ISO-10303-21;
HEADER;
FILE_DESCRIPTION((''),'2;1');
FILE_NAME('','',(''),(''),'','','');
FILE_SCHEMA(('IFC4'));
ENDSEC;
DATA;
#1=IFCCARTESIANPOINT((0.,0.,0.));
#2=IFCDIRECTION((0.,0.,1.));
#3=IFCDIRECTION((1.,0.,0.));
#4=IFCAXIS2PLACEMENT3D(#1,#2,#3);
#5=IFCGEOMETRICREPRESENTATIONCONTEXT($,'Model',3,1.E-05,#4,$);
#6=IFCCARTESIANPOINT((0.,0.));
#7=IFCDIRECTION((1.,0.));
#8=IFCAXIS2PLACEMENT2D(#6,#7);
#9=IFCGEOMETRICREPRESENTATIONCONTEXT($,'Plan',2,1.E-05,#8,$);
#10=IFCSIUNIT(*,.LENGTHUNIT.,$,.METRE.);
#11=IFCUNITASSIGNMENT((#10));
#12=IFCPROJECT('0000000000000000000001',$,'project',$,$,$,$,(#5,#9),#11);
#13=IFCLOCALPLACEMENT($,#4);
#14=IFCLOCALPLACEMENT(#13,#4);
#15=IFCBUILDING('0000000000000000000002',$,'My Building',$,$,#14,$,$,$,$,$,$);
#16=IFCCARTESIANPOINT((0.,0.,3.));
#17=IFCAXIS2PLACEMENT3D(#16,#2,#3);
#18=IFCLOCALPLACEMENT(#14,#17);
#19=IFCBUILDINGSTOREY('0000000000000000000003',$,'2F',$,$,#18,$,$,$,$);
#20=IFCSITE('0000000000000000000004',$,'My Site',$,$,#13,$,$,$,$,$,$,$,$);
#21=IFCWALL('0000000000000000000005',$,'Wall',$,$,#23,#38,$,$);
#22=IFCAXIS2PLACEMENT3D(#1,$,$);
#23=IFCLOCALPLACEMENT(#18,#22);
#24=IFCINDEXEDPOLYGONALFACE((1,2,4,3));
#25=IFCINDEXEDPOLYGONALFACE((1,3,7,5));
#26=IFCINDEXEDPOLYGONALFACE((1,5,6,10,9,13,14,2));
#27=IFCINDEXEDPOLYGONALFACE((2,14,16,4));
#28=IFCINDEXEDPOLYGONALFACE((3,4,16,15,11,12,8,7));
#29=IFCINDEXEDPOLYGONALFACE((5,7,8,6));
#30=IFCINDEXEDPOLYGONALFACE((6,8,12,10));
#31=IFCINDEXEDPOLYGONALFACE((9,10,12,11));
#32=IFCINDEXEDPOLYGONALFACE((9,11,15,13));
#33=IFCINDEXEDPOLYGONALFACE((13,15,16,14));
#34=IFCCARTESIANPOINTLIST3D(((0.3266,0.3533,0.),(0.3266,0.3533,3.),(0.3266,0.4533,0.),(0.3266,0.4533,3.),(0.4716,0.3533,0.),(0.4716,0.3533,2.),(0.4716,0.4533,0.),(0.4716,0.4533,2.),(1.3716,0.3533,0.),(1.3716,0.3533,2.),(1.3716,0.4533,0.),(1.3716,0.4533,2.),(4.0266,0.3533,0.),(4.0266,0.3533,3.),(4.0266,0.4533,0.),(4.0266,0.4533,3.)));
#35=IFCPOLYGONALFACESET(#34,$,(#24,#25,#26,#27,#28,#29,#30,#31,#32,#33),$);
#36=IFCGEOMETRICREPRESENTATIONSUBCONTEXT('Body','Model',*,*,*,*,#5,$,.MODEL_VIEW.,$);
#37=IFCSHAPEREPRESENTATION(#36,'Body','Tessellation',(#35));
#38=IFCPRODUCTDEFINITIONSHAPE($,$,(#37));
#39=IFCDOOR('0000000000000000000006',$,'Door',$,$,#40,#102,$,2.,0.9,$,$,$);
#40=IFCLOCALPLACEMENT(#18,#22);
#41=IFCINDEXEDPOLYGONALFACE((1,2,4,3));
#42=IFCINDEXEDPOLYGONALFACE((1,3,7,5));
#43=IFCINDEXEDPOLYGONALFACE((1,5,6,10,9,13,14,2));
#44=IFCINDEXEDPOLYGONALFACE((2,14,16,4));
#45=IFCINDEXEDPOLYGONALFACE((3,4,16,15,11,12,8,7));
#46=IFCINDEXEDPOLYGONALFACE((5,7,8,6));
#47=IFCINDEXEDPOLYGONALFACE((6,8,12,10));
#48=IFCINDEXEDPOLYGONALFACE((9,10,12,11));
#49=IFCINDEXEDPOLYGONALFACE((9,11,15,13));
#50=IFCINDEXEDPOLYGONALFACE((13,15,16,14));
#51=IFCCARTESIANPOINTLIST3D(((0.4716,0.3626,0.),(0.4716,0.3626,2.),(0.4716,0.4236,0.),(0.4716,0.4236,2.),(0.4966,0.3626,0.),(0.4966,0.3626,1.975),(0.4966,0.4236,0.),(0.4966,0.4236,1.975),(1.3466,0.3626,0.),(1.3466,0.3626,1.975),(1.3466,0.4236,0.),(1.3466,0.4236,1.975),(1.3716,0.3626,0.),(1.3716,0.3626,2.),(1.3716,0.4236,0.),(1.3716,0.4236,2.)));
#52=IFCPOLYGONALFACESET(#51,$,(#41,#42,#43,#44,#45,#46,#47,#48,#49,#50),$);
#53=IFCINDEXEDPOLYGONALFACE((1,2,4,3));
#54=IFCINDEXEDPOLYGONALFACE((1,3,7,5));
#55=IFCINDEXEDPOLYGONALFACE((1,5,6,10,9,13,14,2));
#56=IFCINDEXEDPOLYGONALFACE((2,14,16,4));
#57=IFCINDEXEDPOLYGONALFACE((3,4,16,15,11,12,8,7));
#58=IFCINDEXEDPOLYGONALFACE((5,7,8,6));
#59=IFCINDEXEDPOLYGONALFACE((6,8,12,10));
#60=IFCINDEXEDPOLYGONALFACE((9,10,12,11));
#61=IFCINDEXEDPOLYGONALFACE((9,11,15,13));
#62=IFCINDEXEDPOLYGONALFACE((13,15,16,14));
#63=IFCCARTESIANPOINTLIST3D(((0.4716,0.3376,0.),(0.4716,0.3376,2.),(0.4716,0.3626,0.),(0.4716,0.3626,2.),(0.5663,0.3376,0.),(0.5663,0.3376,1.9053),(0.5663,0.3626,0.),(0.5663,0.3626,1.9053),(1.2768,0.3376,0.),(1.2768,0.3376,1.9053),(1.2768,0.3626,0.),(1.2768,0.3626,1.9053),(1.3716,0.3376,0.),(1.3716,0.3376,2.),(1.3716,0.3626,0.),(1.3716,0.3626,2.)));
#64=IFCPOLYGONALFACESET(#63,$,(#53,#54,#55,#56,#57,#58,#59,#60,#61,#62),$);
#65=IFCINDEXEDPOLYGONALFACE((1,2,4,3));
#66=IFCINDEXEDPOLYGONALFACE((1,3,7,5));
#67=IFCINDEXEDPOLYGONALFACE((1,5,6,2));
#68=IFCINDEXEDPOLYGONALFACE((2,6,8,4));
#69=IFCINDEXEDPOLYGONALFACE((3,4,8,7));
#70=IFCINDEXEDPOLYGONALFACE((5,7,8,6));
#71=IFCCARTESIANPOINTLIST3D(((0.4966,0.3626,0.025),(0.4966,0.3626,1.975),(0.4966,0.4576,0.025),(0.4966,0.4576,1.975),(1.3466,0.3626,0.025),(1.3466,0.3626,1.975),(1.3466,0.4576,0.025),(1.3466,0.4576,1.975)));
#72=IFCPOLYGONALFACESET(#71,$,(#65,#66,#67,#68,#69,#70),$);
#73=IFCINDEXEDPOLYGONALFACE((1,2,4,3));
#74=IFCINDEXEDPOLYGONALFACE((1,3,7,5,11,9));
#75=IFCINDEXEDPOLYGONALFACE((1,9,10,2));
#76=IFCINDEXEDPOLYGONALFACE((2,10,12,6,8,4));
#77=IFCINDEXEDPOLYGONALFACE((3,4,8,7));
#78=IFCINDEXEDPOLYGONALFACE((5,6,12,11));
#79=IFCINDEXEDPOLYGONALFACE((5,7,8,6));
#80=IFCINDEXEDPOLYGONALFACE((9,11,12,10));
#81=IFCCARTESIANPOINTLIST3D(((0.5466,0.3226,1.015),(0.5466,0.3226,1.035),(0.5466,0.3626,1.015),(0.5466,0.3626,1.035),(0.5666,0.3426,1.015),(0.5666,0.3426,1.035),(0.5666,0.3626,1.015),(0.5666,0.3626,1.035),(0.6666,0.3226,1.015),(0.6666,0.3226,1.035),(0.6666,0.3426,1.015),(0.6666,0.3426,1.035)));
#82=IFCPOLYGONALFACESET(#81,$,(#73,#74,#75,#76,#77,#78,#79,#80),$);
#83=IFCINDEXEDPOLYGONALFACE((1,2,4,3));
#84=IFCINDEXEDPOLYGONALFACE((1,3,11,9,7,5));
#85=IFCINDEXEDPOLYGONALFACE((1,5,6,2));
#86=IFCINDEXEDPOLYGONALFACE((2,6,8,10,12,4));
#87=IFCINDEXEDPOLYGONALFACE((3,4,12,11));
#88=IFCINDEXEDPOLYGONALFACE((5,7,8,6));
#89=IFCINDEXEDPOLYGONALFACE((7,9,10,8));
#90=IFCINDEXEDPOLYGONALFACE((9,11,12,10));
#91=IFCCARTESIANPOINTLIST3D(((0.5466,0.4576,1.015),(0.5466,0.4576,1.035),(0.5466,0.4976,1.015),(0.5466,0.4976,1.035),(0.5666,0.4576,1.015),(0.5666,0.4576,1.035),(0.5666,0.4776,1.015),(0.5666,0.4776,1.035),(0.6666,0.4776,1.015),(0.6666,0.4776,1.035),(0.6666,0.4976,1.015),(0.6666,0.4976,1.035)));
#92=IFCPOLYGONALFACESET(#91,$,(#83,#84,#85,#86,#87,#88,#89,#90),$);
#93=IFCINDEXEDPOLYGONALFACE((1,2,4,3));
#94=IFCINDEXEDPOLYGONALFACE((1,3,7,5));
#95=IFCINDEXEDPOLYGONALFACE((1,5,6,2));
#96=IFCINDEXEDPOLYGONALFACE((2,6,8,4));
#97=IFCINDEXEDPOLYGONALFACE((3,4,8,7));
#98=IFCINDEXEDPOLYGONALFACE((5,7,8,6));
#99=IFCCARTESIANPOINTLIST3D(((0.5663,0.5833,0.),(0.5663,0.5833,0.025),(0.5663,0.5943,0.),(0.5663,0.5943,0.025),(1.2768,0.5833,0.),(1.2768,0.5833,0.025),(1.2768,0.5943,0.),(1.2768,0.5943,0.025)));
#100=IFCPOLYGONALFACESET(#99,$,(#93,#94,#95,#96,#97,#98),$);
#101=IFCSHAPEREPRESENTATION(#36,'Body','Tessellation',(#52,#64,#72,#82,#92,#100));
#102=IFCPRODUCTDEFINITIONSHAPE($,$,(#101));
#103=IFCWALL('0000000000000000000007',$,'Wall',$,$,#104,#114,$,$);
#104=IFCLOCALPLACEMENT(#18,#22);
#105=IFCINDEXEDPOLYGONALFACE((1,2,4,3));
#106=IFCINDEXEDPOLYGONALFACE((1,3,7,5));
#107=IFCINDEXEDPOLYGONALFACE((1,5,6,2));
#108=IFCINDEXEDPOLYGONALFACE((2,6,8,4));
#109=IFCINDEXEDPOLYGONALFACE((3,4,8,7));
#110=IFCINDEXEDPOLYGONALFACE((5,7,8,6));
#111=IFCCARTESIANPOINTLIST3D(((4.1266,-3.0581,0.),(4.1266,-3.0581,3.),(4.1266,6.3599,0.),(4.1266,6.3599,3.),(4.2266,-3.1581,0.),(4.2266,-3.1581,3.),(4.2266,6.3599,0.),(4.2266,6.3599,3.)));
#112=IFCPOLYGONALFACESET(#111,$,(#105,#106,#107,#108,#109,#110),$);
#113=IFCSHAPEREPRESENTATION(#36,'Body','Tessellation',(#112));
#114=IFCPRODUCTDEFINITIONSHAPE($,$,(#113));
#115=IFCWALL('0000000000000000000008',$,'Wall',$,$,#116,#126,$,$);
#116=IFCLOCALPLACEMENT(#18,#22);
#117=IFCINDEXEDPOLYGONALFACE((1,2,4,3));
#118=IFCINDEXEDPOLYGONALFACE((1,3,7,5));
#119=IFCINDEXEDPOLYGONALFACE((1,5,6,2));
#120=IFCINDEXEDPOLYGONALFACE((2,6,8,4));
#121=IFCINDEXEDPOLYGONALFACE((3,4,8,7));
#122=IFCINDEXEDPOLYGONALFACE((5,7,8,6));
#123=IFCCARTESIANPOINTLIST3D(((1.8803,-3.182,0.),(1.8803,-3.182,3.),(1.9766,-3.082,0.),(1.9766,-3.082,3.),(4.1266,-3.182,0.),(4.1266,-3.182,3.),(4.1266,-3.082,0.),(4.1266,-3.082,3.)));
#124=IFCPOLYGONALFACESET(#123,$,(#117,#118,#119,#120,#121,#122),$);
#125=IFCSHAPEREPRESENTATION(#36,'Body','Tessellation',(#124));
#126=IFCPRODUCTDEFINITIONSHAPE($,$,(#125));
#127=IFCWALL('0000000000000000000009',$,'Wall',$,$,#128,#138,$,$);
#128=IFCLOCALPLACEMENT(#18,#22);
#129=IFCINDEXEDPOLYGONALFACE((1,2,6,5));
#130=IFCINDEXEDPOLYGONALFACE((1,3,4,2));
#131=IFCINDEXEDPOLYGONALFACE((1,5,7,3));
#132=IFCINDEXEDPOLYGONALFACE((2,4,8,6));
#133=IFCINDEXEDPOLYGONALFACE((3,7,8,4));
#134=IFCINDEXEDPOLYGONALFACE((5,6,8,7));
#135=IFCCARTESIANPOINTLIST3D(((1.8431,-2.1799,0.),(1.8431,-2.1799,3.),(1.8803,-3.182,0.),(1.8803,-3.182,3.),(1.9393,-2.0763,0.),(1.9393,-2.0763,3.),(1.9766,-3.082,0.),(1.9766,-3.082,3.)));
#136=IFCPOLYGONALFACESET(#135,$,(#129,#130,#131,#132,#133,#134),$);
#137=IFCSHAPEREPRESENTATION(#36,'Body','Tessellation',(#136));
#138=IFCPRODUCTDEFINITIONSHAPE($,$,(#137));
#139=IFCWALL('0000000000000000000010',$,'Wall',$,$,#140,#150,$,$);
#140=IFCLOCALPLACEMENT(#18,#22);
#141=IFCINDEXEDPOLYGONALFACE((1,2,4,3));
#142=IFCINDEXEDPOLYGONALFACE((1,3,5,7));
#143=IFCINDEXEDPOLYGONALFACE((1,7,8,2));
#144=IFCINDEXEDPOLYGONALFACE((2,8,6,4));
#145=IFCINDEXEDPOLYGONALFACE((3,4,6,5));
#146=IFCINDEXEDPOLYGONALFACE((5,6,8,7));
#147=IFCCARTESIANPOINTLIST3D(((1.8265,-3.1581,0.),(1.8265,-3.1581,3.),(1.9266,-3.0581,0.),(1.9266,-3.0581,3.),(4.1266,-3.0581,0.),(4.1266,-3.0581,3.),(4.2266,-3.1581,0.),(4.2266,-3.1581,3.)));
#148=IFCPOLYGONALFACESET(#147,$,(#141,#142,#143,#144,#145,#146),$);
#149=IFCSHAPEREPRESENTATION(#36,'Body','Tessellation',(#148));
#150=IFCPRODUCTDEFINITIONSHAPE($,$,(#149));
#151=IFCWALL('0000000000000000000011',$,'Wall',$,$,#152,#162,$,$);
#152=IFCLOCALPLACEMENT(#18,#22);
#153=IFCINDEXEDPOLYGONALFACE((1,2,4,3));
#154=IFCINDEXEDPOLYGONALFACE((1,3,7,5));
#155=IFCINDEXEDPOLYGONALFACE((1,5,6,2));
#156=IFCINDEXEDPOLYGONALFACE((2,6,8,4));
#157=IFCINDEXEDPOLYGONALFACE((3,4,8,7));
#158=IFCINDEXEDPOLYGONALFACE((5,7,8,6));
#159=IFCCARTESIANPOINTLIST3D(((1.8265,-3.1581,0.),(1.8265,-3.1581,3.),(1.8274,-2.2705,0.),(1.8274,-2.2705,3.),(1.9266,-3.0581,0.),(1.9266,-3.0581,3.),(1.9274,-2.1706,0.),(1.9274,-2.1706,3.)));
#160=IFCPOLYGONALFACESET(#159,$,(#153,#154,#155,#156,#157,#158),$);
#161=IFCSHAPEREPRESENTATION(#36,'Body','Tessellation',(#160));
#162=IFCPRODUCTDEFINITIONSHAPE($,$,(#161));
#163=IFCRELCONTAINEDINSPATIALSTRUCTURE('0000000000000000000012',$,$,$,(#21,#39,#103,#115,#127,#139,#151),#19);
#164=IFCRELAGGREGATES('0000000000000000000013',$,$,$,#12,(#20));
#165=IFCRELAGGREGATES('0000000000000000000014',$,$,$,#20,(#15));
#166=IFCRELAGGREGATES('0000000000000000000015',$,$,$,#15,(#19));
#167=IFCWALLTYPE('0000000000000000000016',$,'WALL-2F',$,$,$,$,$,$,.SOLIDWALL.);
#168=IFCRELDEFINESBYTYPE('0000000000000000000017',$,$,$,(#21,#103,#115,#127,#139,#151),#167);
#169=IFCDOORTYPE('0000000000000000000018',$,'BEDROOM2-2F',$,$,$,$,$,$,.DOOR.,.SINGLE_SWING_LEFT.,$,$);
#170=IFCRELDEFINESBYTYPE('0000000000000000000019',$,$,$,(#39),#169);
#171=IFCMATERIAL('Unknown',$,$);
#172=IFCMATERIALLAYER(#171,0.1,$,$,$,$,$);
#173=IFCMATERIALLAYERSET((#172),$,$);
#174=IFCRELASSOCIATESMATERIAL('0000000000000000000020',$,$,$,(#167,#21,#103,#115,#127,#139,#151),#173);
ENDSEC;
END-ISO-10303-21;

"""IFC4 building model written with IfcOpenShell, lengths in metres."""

from ifc_helpers import new_model, entity, si_unit, frame, origin_with_axes, origin_2d_with_axis, place, context, subcontext, project, spatial, line, indexed_curve, outline, extrude, shape, source, transform, mapped, material, layer, layer_set, layer_usage, type_object, type_shapes, element, fill, save


model = new_model("IFC4")

# Units and contexts
model_context = context("Model", 3, precision=1e-05, world=origin_with_axes())
plan_context = context("Plan", 2, precision=1e-05, world=origin_2d_with_axis())
body_context_1 = subcontext(model_context, "Body", "Model", "MODEL_VIEW")
body_context_2 = subcontext(plan_context, "Body", "Plan", "PLAN_VIEW")
ifc_project = project(units=[si_unit("LENGTHUNIT", "METRE")], contexts=[model_context, plan_context])

# Site, building, storey
site_placement = place(None, origin_with_axes())
site = spatial("IfcSite", under=ifc_project, at=site_placement, Name="My Site")
building_placement = place(site_placement, origin_with_axes())
building = spatial("IfcBuilding", under=site, at=building_placement, Name="My Building")
storey_placement = place(building_placement, frame((0.0, 0.0, 3.0), z_axis=(0.0, 0.0, 1.0), x_axis=(1.0, 0.0, 0.0)))
storey = spatial("IfcBuildingStorey", under=building, at=storey_placement, Name="2F")

# Shared definitions
ifc_material = material(Name="Unknown")

# Shared definitions
ifc_layer_1 = layer(ifc_material, 0.1)
ifc_layer_set_1 = layer_set([ifc_layer_1])
wall_type = type_object("IfcWallType", Name="WALL-2F", PredefinedType="SOLIDWALL", material=ifc_layer_set_1)

# Wall, opening, door
ifc_layer_usage_1 = layer_usage(ifc_layer_set_1, "AXIS2", "POSITIVE", 0.0)
wall_1_placement = place(storey_placement, frame((4.0266, 0.4533, 0.0), z_axis=(0.0, 0.0, 1.0), x_axis=(-1.0, 0.0, 0.0)))
wall_1 = element("IfcWall", 1, at=wall_1_placement, inside=storey, type_object=wall_type, material=ifc_layer_usage_1, Name="Wall", context=body_context_1, shape_type="SweptSolid", body=[
    extrude(outline(indexed_curve([(0.0, 0.0), (0.0, 0.1), (3.7, 0.1), (3.7, 0.0)], segments=[line(1, 2, 3, 4, 1)])), origin_with_axes(), (0.0, 0.0, 1.0), 3.0),
])
shared_shape_1 = source(origin_with_axes(), body_context_1, "Body", "SweptSolid", [
    extrude(outline(indexed_curve([(0.0, 0.0), (0.9, 0.0), (0.9, 2.0), (0.0, 2.0)], segments=[line(1, 2, 3, 4, 1)])), frame((0.0, -0.6, 0.0), z_axis=(0.0, -1.0, 0.0), x_axis=(1.0, 0.0, 0.0)), (0.0, 0.0, -1.0), 1.2),
])
opening_1_placement = place(wall_1_placement, frame((3.5551, 0.1, 0.0), z_axis=(0.0, 0.0, 1.0), x_axis=(-1.0, 0.0, 0.0)))
opening_1 = element("IfcOpeningElement", 2, at=opening_1_placement, cuts=wall_1, PredefinedType="OPENING", context=body_context_1, shape_type="MappedRepresentation", body=[
    mapped(shared_shape_1, transform((0.0, 0.0, 0.0), x_axis=(1.0, 0.0, 0.0), y_axis=(0.0, 1.0, 0.0), z_axis=(0.0, 0.0, 1.0), scale=1.0)),
])
door_type_1 = type_object("IfcDoorType", Name="BEDROOM2-2F", OperationType="SINGLE_SWING_LEFT", PredefinedType="DOOR")
shared_shape_2 = source(origin_with_axes(), body_context_1, "Body", "SweptSolid", [
    extrude(outline(indexed_curve([(0.0, 0.0), (0.0, 2.0), (0.9, 2.0), (0.9, 0.0), (0.875, 0.0), (0.875, 1.975), (0.025, 1.975), (0.025, 0.0)], segments=[line(1, 2, 3, 4, 5, 6, 7, 8, 1)])), frame((0.0, 0.0093, 0.0), z_axis=(0.0, -1.0, 0.0), x_axis=(1.0, 0.0, 0.0)), (0.0, 0.0, -1.0), 0.061),
    extrude(outline(indexed_curve([(0.0, 0.0), (0.0, 2.0), (0.9, 2.0), (0.9, 0.0), (0.8053, 0.0), (0.8053, 1.9053), (0.0947, 1.9053), (0.0947, 0.0)], segments=[line(1, 2, 3, 4, 5, 6, 7, 8, 1)])), frame((0.0, -0.0157, 0.0), z_axis=(0.0, -1.0, 0.0), x_axis=(1.0, 0.0, 0.0)), (0.0, 0.0, -1.0), 0.025),
    extrude(outline(indexed_curve([(0.0, 0.0), (0.85, 0.0), (0.85, 0.095), (0.0, 0.095)], segments=[line(1, 2, 3, 4, 1)])), frame((0.025, 0.0093, 0.025), z_axis=(0.0, 0.0, 1.0), x_axis=(1.0, 0.0, 0.0)), (0.0, 0.0, 1.0), 1.95),
    extrude(outline(indexed_curve([(0.0, 0.0), (0.0, -0.04), (0.12, -0.04), (0.12, -0.02), (0.02, -0.02), (0.02, 0.0)], segments=[line(1, 2, 3, 4, 5, 6, 1)])), frame((0.075, 0.0093, 1.015), z_axis=(0.0, 0.0, 1.0), x_axis=(1.0, 0.0, 0.0)), (0.0, 0.0, 1.0), 0.02),
    extrude(outline(indexed_curve([(0.0, 0.0), (0.0, 0.04), (0.12, 0.04), (0.12, 0.02), (0.02, 0.02), (0.02, 0.0)], segments=[line(1, 2, 3, 4, 5, 6, 1)])), frame((0.075, 0.1043, 1.015), z_axis=(0.0, 0.0, 1.0), x_axis=(1.0, 0.0, 0.0)), (0.0, 0.0, 1.0), 0.02),
    extrude(outline(indexed_curve([(0.0, 0.0), (0.7105, 0.0), (0.7105, 0.011), (0.0, 0.011)], segments=[line(1, 2, 3, 4, 1)])), frame((0.0947, 0.23, 0.0), z_axis=(0.0, 0.0, 1.0), x_axis=(1.0, 0.0, 0.0)), (0.0, 0.0, 1.0), 0.025),
])
shared_shape_3 = source(origin_with_axes(), body_context_2, "Body", "Curve2D", [
    entity("IfcIndexedPolyCurve", entity("IfcCartesianPointList2D", [[0.0, -0.0157], [0.0, 0.0703], [0.025, 0.0703], [0.025, 0.0093], [0.0947, 0.0093], [0.0947, -0.0157]]), [entity("IfcLineIndex", [1, 2, 3, 4, 5, 6, 1])]),
    entity("IfcIndexedPolyCurve", entity("IfcCartesianPointList2D", [[0.9, -0.0157], [0.9, 0.0703], [0.875, 0.0703], [0.875, 0.0093], [0.8053, 0.0093], [0.8053, -0.0157]]), [entity("IfcLineIndex", [1, 2, 3, 4, 5, 6, 1])]),
    entity("IfcTrimmedCurve", entity("IfcEllipse", entity("IfcAxis2Placement2D", entity("IfcCartesianPoint", [0.78, 0.0703]), entity("IfcDirection", [1.0, 0.0])), 0.755, 0.85), [entity("IfcCartesianPoint", [0.78, 0.9203])], [entity("IfcCartesianPoint", [0.025, 0.0703])], True, "CARTESIAN"),
    entity("IfcIndexedPolyCurve", entity("IfcCartesianPointList2D", [[0.875, 0.0703], [0.78, 0.0703], [0.78, 0.9203], [0.875, 0.9203]]), [entity("IfcLineIndex", [1, 2, 3, 4, 1])]),
])
type_shapes(door_type_1, [shared_shape_2, shared_shape_3])
door_1_placement = place(opening_1_placement, frame((0.0, 0.0, 0.0), z_axis=(0.0, 0.0, 1.0), x_axis=(1.0, 0.0, 0.0)))
door_1 = element("IfcDoor", 3, at=door_1_placement, inside=storey, type_object=door_type_1, Name="Door", OverallHeight=2.0, OverallWidth=0.9, shapes=[
    shape(body_context_1, "Body", "MappedRepresentation", [mapped(shared_shape_2, transform((0.0, 0.0, 0.0), x_axis=(1.0, 0.0, 0.0), y_axis=(0.0, 1.0, 0.0), z_axis=(0.0, 0.0, 1.0), scale=1.0))]),
    shape(body_context_2, "Body", "MappedRepresentation", [mapped(shared_shape_3, transform((0.0, 0.0, 0.0), x_axis=(1.0, 0.0, 0.0), y_axis=(0.0, 1.0, 0.0), z_axis=(0.0, 0.0, 1.0), scale=1.0))]),
])
fill(opening_1, door_1)

# Walls
ifc_layer_usage_2 = layer_usage(ifc_layer_set_1, "AXIS2", "POSITIVE", 0.0)
wall_2_placement = place(storey_placement, frame((4.1266, 6.3599, 0.0), z_axis=(0.0, 0.0, 1.0), x_axis=(0.0, -1.0, 0.0)))
element("IfcWall", 4, at=wall_2_placement, inside=storey, type_object=wall_type, material=ifc_layer_usage_2, Name="Wall", context=body_context_1, shape_type="SweptSolid", body=[
    extrude(outline(indexed_curve([(0.0, 0.0), (0.0, 0.1), (9.518, 0.1), (9.418, 0.0)], segments=[line(1, 2, 3, 4, 1)])), origin_with_axes(), (0.0, 0.0, 1.0), 3.0),
])
ifc_layer_usage_3 = layer_usage(ifc_layer_set_1, "AXIS2", "POSITIVE", 0.0)
wall_3_placement = place(storey_placement, frame((4.1266, -3.082, 0.0), z_axis=(0.0, 0.0, 1.0), x_axis=(-1.0, 0.0, 0.0)))
element("IfcWall", 5, at=wall_3_placement, inside=storey, type_object=wall_type, material=ifc_layer_usage_3, Name="Wall", context=body_context_1, shape_type="SweptSolid", body=[
    extrude(outline(indexed_curve([(0.0, 0.0), (0.0, 0.1), (2.2464, 0.1), (2.15, 0.0)], segments=[line(1, 2, 3, 4, 1)])), origin_with_axes(), (0.0, 0.0, 1.0), 3.0),
])
ifc_layer_usage_4 = layer_usage(ifc_layer_set_1, "AXIS2", "POSITIVE", 0.0)
wall_4_placement = place(storey_placement, frame((1.9766, -3.082, 0.0), z_axis=(0.0, 0.0, 1.0), x_axis=(-0.037088, 0.999312, 0.0)))
element("IfcWall", 6, at=wall_4_placement, inside=storey, type_object=wall_type, material=ifc_layer_usage_4, Name="Wall", context=body_context_1, shape_type="SweptSolid", body=[
    extrude(outline(indexed_curve([(0.0, 0.0), (-0.0964, 0.1), (0.9064, 0.1), (1.0064, 0.0)], segments=[line(1, 2, 3, 4, 1)])), origin_with_axes(), (0.0, 0.0, 1.0), 3.0),
])
ifc_layer_usage_5 = layer_usage(ifc_layer_set_1, "AXIS2", "POSITIVE", 0.0)
wall_5_placement = place(storey_placement, frame((4.1266, -3.0581, 0.0), z_axis=(0.0, 0.0, 1.0), x_axis=(-1.0, 0.0, 0.0)))
element("IfcWall", 7, at=wall_5_placement, inside=storey, type_object=wall_type, material=ifc_layer_usage_5, Name="Wall", context=body_context_1, shape_type="SweptSolid", body=[
    extrude(outline(indexed_curve([(0.0, 0.0), (-0.1, 0.1), (2.3001, 0.1), (2.2, 0.0)], segments=[line(1, 2, 3, 4, 1)])), origin_with_axes(), (0.0, 0.0, 1.0), 3.0),
])
ifc_layer_usage_6 = layer_usage(ifc_layer_set_1, "AXIS2", "POSITIVE", 0.0)
wall_6_placement = place(storey_placement, frame((1.9266, -3.0581, 0.0), z_axis=(0.0, 0.0, 1.0), x_axis=(0.000947, 1.0, 0.0)))
element("IfcWall", 8, at=wall_6_placement, inside=storey, type_object=wall_type, material=ifc_layer_usage_6, Name="Wall", context=body_context_1, shape_type="SweptSolid", body=[
    extrude(outline(indexed_curve([(0.0, 0.0), (-0.1001, 0.1), (0.7875, 0.1), (0.8875, 0.0)], segments=[line(1, 2, 3, 4, 1)])), origin_with_axes(), (0.0, 0.0, 1.0), 3.0),
])

save(model, "model.ifc")
